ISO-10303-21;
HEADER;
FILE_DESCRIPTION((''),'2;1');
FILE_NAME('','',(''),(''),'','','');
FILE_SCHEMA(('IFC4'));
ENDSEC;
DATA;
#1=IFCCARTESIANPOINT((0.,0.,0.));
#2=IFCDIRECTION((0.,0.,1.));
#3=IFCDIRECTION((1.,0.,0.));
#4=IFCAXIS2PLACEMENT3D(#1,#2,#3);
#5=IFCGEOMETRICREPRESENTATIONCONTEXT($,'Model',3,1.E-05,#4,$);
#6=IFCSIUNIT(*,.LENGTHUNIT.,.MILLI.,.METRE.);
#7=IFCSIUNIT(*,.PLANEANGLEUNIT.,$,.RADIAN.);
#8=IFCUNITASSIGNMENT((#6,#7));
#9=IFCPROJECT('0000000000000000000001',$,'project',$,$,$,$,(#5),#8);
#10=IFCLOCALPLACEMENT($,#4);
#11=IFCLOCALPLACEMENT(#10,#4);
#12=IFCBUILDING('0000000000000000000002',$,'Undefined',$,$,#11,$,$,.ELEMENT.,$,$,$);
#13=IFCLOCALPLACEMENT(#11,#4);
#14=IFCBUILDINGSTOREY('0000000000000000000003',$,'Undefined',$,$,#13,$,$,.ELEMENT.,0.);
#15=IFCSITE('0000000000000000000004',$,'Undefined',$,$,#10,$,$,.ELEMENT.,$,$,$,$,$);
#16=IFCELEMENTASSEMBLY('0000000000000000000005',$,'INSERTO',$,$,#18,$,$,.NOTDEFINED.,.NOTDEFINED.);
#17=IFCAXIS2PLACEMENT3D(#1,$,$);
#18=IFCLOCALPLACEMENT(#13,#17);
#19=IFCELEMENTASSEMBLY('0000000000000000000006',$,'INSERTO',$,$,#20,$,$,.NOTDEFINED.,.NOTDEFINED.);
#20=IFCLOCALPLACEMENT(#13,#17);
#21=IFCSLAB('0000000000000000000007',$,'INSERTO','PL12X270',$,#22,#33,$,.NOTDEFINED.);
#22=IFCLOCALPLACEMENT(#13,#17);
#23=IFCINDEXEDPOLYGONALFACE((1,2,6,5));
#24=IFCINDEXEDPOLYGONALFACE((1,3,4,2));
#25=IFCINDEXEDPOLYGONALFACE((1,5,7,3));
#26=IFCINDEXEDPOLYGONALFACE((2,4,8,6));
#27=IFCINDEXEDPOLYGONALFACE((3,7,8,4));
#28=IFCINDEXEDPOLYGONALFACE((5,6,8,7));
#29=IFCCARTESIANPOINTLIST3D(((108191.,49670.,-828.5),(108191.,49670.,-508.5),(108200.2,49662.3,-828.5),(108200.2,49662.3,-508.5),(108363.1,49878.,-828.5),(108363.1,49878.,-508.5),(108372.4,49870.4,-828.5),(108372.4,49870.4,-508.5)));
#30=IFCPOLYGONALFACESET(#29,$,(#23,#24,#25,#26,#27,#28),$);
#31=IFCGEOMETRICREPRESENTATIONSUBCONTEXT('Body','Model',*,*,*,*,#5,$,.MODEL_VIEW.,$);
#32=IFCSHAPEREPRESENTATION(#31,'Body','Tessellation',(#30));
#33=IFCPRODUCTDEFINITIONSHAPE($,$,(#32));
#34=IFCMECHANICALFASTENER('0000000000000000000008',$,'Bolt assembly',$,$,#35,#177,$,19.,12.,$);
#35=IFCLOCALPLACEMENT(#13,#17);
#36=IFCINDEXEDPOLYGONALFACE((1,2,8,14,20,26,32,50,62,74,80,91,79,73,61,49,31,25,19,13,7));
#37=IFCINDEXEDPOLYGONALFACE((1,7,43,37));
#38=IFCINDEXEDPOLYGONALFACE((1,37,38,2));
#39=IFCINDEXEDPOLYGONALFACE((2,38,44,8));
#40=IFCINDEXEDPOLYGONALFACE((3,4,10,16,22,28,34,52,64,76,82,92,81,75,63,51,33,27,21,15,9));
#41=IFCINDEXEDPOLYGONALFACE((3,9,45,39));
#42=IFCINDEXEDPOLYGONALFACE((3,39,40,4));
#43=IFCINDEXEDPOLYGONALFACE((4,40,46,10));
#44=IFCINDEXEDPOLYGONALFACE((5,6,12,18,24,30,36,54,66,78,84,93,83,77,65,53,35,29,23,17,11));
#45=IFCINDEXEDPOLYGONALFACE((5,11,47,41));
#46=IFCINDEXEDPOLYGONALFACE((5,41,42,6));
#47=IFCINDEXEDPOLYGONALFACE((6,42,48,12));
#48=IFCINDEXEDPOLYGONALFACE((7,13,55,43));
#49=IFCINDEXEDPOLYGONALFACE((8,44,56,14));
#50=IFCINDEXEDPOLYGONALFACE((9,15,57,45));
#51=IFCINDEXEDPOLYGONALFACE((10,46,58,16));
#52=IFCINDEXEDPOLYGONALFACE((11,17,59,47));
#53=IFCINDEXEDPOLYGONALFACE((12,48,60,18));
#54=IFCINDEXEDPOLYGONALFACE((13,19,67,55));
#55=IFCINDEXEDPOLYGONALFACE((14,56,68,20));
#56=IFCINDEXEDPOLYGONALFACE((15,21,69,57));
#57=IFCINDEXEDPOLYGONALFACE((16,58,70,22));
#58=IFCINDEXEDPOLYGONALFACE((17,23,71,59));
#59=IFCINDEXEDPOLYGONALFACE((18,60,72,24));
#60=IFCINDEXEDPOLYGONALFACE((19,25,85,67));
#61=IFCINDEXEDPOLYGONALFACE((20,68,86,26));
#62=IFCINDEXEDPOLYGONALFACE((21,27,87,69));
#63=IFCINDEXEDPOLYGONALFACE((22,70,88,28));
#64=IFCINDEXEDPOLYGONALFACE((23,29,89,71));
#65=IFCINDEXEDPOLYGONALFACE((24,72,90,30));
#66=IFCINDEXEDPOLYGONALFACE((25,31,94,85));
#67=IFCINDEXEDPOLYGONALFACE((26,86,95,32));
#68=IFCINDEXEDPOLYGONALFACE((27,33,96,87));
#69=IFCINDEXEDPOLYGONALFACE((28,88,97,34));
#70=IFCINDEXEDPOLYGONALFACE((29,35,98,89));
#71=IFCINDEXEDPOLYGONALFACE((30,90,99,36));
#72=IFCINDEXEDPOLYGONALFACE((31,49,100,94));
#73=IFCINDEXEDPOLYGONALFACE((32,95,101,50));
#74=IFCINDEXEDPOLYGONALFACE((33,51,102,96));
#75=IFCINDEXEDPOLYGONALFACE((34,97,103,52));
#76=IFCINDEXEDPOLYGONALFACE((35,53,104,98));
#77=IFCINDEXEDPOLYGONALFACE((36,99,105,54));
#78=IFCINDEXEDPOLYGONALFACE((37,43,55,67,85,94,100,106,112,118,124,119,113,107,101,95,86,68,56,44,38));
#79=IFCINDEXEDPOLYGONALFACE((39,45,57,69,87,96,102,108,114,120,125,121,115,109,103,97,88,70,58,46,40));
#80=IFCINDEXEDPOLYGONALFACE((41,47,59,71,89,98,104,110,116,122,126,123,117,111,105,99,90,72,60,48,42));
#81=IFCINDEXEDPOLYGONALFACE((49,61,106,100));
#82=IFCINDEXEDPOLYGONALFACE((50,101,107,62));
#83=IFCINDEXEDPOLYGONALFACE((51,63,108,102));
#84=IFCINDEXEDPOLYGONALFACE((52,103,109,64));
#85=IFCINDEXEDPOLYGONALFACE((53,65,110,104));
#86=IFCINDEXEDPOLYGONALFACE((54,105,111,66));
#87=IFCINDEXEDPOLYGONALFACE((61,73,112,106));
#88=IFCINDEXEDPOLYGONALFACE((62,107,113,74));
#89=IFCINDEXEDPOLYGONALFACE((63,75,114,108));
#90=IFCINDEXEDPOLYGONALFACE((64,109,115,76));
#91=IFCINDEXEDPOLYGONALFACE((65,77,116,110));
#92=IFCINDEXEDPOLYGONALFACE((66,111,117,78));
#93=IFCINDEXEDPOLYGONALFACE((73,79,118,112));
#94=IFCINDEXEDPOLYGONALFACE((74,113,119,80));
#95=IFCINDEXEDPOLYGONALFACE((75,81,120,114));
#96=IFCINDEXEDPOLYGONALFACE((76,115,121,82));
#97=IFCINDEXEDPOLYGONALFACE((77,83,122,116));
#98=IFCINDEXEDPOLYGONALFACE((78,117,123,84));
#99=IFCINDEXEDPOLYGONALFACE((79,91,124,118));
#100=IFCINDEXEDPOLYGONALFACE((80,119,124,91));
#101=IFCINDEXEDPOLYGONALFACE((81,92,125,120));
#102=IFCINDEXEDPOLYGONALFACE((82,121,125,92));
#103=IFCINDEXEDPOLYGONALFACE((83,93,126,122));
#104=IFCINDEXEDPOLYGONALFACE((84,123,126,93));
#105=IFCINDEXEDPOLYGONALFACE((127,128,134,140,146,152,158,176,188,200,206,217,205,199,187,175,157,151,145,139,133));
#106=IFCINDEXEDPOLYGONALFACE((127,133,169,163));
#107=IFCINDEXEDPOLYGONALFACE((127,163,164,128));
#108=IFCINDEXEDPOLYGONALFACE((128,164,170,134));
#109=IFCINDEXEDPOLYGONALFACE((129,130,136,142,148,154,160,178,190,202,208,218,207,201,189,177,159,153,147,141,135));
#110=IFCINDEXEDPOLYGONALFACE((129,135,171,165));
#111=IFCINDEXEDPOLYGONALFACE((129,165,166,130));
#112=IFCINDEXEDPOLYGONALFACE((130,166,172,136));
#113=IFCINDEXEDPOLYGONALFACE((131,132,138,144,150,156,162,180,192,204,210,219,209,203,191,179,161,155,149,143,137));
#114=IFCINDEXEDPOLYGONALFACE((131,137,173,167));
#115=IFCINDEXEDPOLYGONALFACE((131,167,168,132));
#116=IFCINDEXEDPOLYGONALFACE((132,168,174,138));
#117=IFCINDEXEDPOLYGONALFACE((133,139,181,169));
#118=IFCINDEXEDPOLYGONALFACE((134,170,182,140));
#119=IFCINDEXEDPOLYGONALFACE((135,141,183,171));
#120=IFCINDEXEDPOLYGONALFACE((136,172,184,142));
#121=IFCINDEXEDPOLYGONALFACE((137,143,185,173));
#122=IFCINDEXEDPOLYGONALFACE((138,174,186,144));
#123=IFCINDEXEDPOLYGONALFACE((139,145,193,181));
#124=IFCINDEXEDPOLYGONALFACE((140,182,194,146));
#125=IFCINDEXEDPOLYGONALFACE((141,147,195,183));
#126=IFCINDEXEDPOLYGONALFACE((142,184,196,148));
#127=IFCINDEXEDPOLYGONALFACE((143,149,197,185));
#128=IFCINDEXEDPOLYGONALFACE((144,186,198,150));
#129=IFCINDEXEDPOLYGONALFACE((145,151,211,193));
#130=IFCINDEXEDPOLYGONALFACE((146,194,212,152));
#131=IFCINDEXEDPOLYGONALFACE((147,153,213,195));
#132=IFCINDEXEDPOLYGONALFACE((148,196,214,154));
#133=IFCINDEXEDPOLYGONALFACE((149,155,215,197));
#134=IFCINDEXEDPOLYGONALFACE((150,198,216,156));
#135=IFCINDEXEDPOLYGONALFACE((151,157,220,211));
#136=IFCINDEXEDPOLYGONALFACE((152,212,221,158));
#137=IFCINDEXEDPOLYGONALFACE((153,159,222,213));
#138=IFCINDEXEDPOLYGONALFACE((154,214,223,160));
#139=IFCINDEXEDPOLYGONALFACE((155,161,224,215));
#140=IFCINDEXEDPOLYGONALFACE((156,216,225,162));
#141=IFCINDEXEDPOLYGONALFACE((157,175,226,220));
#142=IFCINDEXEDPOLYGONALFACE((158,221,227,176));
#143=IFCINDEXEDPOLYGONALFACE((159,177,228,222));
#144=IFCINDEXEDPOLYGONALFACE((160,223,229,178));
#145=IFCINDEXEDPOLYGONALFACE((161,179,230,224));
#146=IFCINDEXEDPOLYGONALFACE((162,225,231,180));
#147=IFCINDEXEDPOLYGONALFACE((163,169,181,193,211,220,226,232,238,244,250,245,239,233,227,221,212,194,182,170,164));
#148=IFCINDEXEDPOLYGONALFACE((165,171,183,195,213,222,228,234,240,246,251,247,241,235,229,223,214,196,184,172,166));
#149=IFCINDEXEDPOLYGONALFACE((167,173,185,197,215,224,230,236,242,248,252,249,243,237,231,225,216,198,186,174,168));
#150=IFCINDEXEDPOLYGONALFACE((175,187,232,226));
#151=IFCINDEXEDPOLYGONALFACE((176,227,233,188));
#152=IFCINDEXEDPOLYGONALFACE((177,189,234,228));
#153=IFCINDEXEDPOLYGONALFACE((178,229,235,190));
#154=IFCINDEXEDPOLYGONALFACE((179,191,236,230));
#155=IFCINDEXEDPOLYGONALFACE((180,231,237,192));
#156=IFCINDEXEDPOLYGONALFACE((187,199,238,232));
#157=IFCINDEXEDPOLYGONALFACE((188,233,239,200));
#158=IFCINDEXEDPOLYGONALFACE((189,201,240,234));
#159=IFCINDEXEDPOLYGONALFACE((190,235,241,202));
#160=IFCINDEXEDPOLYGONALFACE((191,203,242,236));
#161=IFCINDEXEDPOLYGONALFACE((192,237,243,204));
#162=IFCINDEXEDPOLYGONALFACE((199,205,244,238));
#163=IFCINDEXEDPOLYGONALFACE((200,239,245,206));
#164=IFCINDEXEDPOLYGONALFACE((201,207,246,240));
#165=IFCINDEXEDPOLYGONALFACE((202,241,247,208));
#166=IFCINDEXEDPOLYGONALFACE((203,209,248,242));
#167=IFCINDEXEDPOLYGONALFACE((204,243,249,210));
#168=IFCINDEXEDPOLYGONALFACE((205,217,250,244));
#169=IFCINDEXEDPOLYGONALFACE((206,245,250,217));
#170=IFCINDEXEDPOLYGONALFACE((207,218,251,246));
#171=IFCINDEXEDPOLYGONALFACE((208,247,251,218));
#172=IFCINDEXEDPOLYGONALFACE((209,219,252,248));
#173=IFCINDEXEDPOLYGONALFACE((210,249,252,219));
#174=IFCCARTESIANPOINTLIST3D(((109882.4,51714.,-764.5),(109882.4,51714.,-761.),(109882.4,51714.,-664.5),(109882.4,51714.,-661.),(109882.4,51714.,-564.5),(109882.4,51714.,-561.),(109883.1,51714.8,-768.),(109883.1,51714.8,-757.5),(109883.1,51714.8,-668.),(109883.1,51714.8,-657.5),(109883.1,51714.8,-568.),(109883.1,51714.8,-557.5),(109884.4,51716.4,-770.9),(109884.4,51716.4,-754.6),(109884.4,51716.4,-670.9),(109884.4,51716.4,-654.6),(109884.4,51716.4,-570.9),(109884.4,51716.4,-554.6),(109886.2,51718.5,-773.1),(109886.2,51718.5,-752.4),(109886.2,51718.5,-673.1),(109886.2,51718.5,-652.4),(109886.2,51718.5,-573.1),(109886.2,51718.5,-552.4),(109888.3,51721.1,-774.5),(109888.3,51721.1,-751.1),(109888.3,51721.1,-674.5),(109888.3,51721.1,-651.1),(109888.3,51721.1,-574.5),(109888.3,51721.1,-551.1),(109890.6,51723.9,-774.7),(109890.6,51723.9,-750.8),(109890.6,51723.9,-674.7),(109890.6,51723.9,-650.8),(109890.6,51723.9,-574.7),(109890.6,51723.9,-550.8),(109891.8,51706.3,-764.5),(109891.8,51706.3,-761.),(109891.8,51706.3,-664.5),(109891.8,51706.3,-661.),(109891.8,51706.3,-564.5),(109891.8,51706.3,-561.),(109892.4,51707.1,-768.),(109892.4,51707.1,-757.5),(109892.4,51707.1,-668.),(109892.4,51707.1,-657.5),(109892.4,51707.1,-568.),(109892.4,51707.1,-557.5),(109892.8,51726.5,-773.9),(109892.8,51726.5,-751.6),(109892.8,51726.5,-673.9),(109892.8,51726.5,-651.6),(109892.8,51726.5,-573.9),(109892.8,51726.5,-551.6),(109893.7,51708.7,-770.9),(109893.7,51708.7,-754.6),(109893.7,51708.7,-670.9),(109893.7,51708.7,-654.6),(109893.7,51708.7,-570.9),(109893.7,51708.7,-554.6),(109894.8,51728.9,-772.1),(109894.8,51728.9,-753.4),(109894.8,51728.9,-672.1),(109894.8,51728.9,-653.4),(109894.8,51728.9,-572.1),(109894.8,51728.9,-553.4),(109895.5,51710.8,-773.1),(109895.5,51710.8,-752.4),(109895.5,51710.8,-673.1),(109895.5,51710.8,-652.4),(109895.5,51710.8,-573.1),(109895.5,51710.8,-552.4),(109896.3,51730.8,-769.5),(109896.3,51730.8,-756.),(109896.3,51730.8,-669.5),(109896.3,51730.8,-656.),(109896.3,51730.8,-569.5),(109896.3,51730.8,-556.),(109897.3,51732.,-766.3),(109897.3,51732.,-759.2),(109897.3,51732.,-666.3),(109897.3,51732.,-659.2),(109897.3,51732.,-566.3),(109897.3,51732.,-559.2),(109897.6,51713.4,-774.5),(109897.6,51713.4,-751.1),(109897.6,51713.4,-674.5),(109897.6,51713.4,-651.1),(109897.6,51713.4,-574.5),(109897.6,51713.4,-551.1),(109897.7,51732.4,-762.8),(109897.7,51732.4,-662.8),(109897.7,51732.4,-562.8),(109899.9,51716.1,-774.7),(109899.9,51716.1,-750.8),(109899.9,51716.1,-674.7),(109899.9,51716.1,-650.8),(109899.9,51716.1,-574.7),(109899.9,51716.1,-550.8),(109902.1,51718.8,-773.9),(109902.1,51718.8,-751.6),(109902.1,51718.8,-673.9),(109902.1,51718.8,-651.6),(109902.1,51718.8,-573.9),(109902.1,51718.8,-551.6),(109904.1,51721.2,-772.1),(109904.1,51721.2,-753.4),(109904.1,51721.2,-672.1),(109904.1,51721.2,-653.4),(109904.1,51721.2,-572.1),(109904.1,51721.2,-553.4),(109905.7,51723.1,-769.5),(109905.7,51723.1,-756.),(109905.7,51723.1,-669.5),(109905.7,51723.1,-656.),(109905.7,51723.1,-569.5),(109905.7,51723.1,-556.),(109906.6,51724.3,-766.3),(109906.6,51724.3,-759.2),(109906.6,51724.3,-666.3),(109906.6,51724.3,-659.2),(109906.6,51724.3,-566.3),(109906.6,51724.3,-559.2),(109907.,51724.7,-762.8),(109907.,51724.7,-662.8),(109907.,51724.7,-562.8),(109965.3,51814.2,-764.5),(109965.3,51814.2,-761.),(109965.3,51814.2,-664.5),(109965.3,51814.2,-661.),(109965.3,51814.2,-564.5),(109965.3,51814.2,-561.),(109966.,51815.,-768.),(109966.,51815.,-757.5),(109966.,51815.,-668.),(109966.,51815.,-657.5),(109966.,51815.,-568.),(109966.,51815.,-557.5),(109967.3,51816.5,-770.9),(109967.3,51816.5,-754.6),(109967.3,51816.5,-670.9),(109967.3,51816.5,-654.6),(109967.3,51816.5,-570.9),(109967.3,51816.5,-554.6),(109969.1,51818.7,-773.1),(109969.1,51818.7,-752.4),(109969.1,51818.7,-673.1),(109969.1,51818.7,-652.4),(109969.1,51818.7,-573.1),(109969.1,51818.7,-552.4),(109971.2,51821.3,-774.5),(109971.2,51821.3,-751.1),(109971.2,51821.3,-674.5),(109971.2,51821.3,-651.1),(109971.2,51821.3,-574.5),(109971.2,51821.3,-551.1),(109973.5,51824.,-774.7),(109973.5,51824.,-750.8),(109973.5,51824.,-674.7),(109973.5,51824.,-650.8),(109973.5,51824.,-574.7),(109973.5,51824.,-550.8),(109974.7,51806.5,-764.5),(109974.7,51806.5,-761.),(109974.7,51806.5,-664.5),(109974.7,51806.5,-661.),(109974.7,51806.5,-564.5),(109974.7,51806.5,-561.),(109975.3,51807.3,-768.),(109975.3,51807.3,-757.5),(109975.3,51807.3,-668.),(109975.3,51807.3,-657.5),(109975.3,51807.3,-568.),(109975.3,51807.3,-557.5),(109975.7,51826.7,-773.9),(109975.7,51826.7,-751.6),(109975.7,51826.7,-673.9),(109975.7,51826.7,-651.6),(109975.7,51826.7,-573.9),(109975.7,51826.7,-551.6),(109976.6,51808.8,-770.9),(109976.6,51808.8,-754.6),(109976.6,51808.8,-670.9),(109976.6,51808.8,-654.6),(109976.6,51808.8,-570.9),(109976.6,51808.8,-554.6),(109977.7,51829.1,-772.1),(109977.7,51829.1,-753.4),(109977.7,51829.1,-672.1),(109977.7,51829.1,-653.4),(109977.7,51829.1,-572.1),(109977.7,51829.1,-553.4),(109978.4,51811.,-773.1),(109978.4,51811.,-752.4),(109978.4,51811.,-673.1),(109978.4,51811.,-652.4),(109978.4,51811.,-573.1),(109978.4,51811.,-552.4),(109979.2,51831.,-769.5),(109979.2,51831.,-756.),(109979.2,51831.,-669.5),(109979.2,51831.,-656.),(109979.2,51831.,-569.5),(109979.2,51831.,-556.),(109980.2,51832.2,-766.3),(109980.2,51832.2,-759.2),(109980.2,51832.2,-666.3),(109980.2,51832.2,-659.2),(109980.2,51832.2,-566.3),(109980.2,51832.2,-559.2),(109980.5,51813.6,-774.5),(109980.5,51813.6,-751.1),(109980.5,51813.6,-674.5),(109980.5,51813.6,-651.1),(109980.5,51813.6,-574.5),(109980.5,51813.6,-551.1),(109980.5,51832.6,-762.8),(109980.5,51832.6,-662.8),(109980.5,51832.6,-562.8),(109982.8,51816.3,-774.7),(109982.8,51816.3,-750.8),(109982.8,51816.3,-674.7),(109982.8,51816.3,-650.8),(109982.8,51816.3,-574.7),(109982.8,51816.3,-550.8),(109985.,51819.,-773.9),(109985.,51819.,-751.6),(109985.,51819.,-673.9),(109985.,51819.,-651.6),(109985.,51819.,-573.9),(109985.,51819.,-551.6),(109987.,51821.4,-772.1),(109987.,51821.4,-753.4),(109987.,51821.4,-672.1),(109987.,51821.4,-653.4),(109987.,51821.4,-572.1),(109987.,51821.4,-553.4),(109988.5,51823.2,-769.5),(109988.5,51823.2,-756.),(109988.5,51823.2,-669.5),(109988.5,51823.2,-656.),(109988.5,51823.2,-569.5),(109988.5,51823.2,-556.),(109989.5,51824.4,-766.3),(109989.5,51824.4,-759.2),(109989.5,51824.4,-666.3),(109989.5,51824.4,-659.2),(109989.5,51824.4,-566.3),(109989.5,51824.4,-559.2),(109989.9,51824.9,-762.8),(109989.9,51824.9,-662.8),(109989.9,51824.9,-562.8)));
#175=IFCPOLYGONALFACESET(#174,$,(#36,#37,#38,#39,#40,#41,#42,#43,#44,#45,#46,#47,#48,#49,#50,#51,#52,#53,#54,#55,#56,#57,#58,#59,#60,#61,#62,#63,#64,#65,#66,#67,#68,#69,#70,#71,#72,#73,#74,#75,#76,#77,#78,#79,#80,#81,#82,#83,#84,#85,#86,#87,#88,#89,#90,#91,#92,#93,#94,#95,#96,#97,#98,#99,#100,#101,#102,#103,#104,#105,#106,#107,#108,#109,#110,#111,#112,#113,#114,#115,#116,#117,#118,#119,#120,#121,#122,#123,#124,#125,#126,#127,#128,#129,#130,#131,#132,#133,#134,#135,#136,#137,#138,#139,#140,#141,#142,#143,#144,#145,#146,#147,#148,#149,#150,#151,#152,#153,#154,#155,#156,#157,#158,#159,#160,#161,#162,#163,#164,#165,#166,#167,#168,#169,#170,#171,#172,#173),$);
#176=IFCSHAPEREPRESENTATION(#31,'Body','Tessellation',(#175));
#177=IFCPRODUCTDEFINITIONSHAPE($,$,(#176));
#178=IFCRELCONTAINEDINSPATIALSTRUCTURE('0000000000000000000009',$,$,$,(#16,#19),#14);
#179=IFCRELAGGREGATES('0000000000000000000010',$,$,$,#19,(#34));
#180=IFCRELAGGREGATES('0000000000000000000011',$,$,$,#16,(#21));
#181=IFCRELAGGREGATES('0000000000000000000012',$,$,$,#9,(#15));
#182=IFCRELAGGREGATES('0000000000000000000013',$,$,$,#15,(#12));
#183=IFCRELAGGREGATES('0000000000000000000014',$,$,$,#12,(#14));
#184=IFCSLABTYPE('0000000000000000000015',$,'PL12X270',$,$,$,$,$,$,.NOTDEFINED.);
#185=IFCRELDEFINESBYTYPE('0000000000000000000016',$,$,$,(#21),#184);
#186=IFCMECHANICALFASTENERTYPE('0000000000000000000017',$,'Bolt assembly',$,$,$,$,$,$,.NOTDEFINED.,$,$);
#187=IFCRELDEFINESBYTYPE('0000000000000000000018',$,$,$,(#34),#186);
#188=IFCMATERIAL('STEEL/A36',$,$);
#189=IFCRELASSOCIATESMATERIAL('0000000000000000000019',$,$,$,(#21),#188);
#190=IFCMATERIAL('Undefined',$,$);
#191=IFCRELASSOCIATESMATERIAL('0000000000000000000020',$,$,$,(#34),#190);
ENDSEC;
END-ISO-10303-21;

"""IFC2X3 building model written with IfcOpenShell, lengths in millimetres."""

from ifc_helpers import new_model, si_unit, frame, origin_with_axes, origin_2d_with_axis, place, context, subcontext, project, spatial, polyline, circle, outline, extrude, source, transform, mapped, material, type_object, element, aggregate, save


model = new_model("IFC2X3")

# Units and contexts
model_context = context("Model", 3, precision=1e-05, world=origin_with_axes())
body_context = subcontext(model_context, "Body", "Model", "MODEL_VIEW")
ifc_project = project(units=[si_unit("LENGTHUNIT", "METRE", prefix="MILLI"), si_unit("PLANEANGLEUNIT", "RADIAN")], contexts=[model_context])

# Site, building, storey
site_placement = place(None, origin_with_axes())
site = spatial("IfcSite", under=ifc_project, at=site_placement, Name="Undefined", CompositionType="ELEMENT")
building_placement = place(site_placement, origin_with_axes())
building = spatial("IfcBuilding", under=site, at=building_placement, Name="Undefined", CompositionType="ELEMENT")
storey_placement = place(building_placement, origin_with_axes())
storey = spatial("IfcBuildingStorey", under=building, at=storey_placement, Name="Undefined", CompositionType="ELEMENT", Elevation=0.0)

# Shared definitions
ifc_material_1 = material(Name="STEEL/A36")

# Element assemblies
assembly_1_placement = place(storey_placement, origin_with_axes())
assembly_1 = element("IfcElementAssembly", 1, at=assembly_1_placement, inside=storey, Name="INSERTO", AssemblyPlace="NOTDEFINED", PredefinedType="NOTDEFINED")
assembly_2_placement = place(storey_placement, origin_with_axes())
assembly_2 = element("IfcElementAssembly", 2, at=assembly_2_placement, inside=storey, Name="INSERTO", AssemblyPlace="NOTDEFINED", PredefinedType="NOTDEFINED")
slab_type_1 = type_object("IfcSlabType", Name="PL12X270", PredefinedType="NOTDEFINED")

# Slab
slab_1_placement = place(assembly_1_placement, frame((108195.6, 49666.2, -508.5), z_axis=(-0.7704, 0.637561, 0.0), x_axis=(0.637561, 0.7704, -0.000001)))
slab_1 = element("IfcSlab", 3, at=slab_1_placement, type_object=slab_type_1, material=ifc_material_1, Name="INSERTO", Description="PL12X270", PredefinedType="NOTDEFINED", context=body_context, shape_type="SweptSolid", body=[
    extrude(outline(polyline([(0.0, 0.0), (270.0, 0.0), (270.0, 320.0), (0.0, 320.0), (0.0, 0.0)])), frame((0.0, 0.0, -6.0), z_axis=(0.0, 0.0, 1.0), x_axis=(1.0, 0.0, 0.0)), (0.0, 0.0, 1.0), 12.0),
])

# Mechanical fastener
ifc_material_2 = material(Name="Undefined")
mechanical_fastener_type = type_object("IfcMechanicalFastenerType", Name="Bolt assembly")
shared_shape_1 = source(origin_with_axes(), body_context, "Body", "SweptSolid", [
    extrude(circle(Radius=12.0, at=origin_2d_with_axis()), frame((0.0, 0.0, 0.0), z_axis=(0.0, 1.0, 0.0), x_axis=(1.0, 0.0, 0.0)), (0.0, 0.0, 1.0), 12.1),
])
mechanical_fastener_1_placement = place(assembly_2_placement, frame((109899.3, 51715.5, -662.8), z_axis=(0.000001, 0.000001, 1.0), x_axis=(0.637563, 0.770399, -0.000002)))
mechanical_fastener_1 = element("IfcMechanicalFastener", 4, at=mechanical_fastener_1_placement, type_object=mechanical_fastener_type, material=ifc_material_2, Name="Bolt assembly", NominalDiameter=19.0, NominalLength=12.0, context=body_context, shape_type="MappedRepresentation", body=[
    mapped(shared_shape_1, transform((0.0, 0.0, -100.0))),
    mapped(shared_shape_1, transform((130.0, 0.0, -100.0))),
    mapped(shared_shape_1, transform((0.0, 0.0, 0.0))),
    mapped(shared_shape_1, transform((130.0, 0.0, 0.0))),
    mapped(shared_shape_1, transform((0.0, 0.0, 100.0))),
    mapped(shared_shape_1, transform((130.0, 0.0, 100.0))),
])
aggregate(assembly_2, [mechanical_fastener_1])
aggregate(assembly_1, [slab_1])

save(model, "model.ifc")
